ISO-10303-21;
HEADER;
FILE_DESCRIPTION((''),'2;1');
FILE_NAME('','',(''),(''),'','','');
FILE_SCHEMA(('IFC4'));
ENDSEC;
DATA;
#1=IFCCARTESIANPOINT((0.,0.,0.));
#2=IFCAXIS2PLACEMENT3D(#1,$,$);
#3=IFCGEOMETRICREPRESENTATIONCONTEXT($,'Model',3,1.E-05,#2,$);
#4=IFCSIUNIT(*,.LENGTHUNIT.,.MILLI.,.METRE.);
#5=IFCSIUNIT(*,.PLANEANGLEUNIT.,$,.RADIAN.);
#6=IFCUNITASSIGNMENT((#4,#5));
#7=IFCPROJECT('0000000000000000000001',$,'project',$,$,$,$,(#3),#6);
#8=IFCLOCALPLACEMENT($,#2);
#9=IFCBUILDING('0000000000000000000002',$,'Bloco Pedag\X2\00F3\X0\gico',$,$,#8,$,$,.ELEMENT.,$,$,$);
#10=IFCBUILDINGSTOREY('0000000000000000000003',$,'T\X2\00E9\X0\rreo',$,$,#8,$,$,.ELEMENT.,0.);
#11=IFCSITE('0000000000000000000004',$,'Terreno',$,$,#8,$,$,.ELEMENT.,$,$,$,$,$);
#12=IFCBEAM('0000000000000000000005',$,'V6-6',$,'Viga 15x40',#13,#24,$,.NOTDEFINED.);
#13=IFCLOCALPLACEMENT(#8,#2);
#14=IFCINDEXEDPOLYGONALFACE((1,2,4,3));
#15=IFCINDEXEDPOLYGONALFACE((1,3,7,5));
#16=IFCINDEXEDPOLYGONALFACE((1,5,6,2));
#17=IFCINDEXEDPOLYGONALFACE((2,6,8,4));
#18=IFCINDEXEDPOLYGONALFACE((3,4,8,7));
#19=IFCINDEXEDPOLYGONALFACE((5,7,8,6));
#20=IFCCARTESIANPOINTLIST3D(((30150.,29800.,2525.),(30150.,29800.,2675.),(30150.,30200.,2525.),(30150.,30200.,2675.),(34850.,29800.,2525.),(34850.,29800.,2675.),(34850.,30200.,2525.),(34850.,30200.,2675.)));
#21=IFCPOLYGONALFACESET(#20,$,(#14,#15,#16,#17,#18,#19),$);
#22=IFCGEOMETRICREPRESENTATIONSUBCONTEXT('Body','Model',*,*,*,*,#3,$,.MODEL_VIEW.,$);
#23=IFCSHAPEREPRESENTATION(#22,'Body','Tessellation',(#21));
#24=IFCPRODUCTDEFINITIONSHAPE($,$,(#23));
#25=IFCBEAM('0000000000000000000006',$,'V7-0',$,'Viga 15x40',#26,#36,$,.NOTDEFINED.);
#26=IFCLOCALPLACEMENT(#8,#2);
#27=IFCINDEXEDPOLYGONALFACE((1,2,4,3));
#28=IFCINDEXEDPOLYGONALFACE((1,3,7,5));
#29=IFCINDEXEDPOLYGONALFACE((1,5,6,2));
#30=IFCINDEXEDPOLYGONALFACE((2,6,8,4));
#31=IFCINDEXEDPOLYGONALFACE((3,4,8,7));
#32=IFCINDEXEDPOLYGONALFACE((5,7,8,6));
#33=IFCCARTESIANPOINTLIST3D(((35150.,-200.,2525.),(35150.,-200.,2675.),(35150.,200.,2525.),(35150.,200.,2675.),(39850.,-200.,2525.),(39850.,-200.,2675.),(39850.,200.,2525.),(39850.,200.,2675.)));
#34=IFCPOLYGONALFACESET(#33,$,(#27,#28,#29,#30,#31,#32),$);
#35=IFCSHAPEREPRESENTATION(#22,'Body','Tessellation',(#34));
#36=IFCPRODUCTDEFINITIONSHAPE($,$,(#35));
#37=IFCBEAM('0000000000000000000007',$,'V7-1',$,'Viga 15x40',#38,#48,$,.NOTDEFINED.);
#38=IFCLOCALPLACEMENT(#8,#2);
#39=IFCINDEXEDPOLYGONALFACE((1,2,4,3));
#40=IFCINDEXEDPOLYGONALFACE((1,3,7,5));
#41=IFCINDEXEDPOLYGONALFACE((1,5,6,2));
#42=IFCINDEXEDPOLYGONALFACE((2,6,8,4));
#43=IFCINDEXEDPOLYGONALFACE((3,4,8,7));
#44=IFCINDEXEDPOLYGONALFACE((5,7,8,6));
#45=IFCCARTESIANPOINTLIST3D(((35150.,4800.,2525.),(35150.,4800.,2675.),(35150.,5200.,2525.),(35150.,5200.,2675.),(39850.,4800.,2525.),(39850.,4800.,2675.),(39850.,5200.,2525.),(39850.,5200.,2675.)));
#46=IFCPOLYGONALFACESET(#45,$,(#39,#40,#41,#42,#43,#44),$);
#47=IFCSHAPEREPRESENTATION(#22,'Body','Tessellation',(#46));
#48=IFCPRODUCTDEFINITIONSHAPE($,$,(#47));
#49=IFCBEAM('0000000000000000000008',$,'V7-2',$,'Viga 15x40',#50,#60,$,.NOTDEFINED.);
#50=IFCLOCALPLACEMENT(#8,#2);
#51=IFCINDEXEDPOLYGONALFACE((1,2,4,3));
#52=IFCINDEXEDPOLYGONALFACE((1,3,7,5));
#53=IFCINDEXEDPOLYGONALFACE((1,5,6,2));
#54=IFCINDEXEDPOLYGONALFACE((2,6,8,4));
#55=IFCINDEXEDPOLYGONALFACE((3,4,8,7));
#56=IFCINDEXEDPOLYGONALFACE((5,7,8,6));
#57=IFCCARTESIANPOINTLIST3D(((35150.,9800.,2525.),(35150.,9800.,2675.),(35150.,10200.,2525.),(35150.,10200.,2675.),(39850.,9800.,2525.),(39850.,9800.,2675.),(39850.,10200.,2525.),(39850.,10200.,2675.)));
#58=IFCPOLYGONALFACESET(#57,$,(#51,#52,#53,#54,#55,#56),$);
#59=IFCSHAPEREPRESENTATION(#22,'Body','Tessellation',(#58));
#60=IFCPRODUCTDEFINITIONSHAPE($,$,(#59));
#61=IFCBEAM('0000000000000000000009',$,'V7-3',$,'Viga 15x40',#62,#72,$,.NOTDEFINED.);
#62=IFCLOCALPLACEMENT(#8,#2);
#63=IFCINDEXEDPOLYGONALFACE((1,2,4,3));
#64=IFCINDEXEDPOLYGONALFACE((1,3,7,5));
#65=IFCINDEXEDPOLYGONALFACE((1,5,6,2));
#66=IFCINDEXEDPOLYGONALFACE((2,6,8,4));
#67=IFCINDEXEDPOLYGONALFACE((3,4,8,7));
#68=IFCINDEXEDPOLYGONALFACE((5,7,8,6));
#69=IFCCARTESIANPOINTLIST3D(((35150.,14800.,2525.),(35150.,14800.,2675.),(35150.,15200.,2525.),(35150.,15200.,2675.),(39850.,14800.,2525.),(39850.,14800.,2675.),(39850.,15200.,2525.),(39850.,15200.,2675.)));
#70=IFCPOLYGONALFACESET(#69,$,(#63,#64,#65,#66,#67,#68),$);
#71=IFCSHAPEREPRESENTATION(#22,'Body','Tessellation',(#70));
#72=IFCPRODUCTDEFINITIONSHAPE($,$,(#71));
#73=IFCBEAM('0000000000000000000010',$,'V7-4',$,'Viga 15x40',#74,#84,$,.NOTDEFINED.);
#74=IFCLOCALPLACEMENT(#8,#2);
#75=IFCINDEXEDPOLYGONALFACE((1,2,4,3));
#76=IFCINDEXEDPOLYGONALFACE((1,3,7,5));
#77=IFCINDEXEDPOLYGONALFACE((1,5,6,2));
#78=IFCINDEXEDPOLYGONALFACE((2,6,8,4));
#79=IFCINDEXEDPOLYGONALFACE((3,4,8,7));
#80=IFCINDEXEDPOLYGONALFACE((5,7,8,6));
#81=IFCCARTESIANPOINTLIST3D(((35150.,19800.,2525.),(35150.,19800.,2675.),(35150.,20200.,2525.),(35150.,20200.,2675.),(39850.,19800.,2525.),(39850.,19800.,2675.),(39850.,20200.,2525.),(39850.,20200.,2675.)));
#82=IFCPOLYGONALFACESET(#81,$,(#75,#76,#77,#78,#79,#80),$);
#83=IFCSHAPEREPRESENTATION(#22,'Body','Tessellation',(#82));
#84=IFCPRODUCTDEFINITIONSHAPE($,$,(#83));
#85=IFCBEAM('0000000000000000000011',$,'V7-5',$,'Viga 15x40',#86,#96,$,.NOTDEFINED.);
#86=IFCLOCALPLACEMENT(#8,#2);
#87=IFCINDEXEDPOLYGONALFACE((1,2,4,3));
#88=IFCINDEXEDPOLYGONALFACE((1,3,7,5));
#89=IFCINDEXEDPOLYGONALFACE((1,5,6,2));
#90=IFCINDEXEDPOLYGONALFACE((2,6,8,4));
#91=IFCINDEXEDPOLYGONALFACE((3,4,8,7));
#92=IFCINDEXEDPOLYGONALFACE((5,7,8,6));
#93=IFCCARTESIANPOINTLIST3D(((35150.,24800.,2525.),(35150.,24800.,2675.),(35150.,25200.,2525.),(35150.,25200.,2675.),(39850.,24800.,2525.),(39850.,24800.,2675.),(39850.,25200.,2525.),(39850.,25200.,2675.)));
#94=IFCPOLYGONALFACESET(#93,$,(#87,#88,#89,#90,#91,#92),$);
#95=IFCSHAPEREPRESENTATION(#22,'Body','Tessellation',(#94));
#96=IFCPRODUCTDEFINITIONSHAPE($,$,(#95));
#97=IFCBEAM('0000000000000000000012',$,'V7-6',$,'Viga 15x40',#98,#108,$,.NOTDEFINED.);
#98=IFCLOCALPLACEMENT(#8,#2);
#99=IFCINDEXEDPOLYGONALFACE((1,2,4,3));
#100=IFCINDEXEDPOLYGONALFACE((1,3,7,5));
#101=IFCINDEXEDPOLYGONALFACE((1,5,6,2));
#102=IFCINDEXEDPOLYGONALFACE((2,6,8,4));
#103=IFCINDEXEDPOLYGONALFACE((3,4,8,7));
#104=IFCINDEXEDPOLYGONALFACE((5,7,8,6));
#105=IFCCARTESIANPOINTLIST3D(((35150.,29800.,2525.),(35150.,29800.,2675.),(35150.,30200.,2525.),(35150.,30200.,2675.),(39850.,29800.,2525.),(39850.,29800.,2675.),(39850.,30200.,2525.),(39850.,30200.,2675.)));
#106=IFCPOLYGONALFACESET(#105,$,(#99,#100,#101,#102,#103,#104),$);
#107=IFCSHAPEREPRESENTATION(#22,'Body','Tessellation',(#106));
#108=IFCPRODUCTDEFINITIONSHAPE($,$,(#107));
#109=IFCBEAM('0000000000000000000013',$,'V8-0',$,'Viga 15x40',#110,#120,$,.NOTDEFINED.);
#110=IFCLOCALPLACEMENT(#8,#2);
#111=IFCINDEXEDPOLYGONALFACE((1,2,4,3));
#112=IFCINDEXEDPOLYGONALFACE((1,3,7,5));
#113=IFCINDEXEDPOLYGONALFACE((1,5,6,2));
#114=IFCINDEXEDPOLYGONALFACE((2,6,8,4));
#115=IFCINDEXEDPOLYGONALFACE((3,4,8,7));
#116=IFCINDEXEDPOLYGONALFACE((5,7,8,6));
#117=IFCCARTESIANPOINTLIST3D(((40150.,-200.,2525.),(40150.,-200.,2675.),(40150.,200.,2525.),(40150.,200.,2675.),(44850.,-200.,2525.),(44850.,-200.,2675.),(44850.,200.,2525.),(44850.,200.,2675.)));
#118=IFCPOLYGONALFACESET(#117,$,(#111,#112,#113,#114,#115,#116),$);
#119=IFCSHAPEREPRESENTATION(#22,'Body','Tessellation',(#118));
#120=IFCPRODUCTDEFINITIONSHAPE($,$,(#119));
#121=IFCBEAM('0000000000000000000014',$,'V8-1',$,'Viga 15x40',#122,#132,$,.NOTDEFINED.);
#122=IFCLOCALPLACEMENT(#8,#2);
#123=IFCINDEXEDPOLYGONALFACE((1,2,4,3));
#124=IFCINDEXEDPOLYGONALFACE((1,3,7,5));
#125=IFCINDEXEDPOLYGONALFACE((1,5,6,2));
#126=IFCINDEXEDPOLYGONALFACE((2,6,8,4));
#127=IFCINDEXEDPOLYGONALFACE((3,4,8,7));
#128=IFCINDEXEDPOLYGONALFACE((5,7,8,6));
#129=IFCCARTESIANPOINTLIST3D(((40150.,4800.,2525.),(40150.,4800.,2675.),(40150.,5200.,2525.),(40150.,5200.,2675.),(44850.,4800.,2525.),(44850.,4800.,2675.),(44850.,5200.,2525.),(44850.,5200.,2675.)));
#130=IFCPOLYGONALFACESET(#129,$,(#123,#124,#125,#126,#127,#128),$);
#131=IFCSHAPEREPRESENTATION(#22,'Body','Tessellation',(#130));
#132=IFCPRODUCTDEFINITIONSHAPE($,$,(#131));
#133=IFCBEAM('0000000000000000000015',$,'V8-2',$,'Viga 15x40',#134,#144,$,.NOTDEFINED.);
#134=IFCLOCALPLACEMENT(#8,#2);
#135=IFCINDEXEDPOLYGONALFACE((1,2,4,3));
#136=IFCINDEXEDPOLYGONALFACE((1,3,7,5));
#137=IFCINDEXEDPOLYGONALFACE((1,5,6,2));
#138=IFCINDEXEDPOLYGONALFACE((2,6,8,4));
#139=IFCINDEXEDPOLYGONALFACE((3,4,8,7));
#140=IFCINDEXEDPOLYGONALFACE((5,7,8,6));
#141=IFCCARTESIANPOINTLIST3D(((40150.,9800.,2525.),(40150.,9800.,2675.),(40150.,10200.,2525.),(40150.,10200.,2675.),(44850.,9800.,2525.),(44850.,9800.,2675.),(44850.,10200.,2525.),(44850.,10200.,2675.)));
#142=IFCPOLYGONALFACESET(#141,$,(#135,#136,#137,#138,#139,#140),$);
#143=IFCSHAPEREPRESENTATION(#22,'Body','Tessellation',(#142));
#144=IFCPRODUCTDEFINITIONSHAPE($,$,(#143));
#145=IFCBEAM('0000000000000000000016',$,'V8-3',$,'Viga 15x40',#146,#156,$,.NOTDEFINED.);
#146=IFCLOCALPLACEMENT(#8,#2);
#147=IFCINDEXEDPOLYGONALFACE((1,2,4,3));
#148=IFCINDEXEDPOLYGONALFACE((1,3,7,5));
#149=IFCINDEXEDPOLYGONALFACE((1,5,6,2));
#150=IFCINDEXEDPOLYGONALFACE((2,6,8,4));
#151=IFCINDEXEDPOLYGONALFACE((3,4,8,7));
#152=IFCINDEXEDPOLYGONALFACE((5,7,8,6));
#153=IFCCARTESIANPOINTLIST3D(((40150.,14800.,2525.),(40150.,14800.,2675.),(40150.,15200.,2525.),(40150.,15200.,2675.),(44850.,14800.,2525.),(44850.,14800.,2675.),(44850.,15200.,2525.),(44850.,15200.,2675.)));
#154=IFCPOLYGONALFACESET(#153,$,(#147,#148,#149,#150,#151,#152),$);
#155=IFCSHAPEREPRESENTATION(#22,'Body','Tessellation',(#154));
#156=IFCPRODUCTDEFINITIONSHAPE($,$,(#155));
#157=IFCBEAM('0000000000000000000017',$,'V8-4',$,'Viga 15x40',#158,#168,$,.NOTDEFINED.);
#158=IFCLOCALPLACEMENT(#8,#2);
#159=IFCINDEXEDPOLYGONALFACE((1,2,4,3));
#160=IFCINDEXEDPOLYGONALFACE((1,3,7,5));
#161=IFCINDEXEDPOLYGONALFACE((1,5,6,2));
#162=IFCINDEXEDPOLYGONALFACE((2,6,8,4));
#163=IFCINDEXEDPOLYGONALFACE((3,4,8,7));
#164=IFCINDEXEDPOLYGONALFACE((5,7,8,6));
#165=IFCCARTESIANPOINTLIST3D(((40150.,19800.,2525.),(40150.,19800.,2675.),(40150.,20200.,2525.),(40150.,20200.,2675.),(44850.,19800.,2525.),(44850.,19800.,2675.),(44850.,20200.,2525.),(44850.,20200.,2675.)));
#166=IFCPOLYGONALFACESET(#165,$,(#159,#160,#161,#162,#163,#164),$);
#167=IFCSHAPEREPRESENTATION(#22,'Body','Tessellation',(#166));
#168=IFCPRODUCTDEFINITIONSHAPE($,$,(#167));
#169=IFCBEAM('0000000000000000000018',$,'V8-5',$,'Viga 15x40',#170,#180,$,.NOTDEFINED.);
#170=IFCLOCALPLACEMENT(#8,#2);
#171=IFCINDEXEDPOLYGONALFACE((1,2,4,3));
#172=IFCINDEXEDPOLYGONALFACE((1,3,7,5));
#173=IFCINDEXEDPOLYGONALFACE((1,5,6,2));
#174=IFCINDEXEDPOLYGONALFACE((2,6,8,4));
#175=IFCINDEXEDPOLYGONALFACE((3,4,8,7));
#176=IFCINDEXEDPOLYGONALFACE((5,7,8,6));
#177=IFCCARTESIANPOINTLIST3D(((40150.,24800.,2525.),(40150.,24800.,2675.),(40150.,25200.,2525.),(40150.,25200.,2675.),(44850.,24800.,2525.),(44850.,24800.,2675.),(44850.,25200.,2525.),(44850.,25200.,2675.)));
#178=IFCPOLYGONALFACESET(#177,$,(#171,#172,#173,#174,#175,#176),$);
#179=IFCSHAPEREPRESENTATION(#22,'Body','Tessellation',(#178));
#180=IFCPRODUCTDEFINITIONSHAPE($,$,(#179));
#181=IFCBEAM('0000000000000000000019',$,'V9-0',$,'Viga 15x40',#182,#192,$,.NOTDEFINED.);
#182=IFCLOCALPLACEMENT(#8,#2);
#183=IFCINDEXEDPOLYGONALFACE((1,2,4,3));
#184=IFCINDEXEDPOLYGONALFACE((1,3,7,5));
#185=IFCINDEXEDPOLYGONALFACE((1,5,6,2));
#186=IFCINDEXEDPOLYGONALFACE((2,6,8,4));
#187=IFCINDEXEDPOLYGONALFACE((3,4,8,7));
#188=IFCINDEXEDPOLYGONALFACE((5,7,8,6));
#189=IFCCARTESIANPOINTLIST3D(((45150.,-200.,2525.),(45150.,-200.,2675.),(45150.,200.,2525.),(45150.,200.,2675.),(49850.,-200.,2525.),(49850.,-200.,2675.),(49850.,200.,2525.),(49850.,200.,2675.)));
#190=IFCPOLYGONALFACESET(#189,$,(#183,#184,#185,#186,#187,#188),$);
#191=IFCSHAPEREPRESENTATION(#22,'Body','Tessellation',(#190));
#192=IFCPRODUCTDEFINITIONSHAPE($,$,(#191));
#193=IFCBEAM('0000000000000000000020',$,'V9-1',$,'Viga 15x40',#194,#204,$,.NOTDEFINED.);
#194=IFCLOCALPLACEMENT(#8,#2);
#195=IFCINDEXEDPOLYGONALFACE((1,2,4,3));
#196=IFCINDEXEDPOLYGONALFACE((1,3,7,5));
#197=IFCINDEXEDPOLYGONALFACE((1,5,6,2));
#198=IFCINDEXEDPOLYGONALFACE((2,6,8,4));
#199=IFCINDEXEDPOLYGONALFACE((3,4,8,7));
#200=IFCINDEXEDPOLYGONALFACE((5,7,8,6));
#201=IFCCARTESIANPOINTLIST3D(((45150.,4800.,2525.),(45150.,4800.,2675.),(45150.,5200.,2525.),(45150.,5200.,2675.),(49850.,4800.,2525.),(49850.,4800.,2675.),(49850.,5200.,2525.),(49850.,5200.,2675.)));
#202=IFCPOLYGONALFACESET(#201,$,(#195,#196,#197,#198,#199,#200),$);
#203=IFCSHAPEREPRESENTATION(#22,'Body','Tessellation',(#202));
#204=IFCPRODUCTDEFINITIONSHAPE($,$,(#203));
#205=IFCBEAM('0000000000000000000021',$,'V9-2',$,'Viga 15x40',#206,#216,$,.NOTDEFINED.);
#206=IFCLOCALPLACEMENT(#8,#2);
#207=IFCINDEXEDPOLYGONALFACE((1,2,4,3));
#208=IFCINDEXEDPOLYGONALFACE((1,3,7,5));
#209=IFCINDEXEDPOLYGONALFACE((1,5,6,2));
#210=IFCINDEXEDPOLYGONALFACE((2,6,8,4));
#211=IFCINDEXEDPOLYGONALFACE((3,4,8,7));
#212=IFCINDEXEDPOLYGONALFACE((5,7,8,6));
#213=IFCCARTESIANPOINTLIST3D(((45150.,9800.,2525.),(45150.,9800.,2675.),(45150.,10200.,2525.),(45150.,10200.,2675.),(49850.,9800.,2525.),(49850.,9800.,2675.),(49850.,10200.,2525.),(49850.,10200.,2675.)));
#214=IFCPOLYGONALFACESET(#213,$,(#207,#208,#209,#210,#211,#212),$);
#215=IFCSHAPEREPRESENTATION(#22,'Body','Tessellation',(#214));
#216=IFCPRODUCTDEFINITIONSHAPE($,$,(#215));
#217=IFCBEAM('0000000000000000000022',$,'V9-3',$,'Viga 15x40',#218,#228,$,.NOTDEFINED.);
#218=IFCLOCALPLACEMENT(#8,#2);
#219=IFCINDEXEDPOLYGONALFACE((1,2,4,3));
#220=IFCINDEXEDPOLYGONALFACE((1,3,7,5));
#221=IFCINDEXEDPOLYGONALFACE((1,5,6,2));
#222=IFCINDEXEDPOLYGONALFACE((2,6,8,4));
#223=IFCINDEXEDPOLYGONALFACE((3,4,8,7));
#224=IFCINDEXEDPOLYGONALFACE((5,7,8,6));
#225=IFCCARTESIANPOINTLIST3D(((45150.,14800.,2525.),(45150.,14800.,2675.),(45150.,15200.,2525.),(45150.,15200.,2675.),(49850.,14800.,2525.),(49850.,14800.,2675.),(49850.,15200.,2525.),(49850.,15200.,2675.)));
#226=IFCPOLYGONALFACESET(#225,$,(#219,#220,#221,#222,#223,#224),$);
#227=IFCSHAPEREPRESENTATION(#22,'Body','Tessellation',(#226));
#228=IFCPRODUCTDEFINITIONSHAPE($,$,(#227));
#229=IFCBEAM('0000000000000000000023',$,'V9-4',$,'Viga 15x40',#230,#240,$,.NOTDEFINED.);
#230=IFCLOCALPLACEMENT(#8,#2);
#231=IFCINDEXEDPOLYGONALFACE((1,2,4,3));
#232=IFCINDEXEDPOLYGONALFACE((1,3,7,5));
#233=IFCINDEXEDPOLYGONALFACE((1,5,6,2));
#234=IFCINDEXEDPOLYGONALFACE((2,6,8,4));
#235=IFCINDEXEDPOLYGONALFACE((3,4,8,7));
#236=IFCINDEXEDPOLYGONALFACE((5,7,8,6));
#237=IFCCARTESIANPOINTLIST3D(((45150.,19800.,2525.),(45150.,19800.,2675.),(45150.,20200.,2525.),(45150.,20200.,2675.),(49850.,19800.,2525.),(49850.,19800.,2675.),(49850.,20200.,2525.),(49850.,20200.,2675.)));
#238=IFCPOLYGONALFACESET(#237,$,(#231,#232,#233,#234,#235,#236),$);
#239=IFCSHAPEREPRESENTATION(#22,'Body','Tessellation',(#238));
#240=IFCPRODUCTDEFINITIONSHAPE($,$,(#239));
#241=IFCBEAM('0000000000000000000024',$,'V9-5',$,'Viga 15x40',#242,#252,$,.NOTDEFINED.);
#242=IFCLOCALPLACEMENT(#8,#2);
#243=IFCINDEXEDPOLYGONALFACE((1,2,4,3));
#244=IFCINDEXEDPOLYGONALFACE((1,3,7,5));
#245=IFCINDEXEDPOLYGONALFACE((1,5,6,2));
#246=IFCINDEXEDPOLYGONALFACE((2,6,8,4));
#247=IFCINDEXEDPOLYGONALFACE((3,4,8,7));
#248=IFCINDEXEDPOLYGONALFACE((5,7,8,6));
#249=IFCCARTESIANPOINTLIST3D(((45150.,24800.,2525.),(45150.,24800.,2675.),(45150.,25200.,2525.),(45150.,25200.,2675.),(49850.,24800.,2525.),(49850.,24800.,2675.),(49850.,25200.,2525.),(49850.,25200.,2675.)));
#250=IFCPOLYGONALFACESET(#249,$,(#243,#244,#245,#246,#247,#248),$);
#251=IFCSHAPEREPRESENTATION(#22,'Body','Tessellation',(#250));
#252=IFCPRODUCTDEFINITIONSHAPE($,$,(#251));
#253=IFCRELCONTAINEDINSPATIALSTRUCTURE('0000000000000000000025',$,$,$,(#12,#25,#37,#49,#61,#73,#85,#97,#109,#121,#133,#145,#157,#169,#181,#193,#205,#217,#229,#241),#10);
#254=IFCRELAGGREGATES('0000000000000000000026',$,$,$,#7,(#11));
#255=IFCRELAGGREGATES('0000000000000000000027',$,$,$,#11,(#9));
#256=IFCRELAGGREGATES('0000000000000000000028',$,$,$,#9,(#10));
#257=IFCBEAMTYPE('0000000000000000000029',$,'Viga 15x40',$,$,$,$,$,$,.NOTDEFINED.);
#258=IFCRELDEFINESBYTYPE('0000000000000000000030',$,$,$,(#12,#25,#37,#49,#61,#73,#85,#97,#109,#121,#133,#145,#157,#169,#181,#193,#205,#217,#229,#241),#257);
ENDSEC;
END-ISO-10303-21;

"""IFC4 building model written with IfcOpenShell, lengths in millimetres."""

from ifc_helpers import new_model, si_unit, frame, origin, origin_2d, place, context, subcontext, project, spatial, rectangle, extrude, type_object, element, save


model = new_model("IFC4")

# Units and contexts
model_context = context("Model", 3, precision=1e-05, world=origin())
body_context = subcontext(model_context, "Body", "Model", "MODEL_VIEW")
ifc_project = project(units=[si_unit("LENGTHUNIT", "METRE", prefix="MILLI"), si_unit("PLANEANGLEUNIT", "RADIAN")], contexts=[model_context])

# Site, building, storey
placement = place(None, origin())
site = spatial("IfcSite", under=ifc_project, at=placement, Name="Terreno", CompositionType="ELEMENT")
building = spatial("IfcBuilding", under=site, at=placement, Name="Bloco Pedagógico", CompositionType="ELEMENT")
storey = spatial("IfcBuildingStorey", under=building, at=placement, Name="Térreo", CompositionType="ELEMENT", Elevation=0.0)

# Beams
beam_type = type_object("IfcBeamType", Name="Viga 15x40", PredefinedType="NOTDEFINED")
for number, where, z_axis, x_axis, name in (
    (1, (30150.0, 30000.0, 2600.0), (1.0, 0.0, 0.0), (0.0, 1.0, 0.0), "V6-6"),
    (2, (35150.0, 0.0, 2600.0), (1.0, 0.0, 0.0), (0.0, 1.0, 0.0), "V7-0"),
    (3, (35150.0, 5000.0, 2600.0), (1.0, 0.0, 0.0), (0.0, 1.0, 0.0), "V7-1"),
    (4, (35150.0, 10000.0, 2600.0), (1.0, 0.0, 0.0), (0.0, 1.0, 0.0), "V7-2"),
    (5, (35150.0, 15000.0, 2600.0), (1.0, 0.0, 0.0), (0.0, 1.0, 0.0), "V7-3"),
    (6, (35150.0, 20000.0, 2600.0), (1.0, 0.0, 0.0), (0.0, 1.0, 0.0), "V7-4"),
    (7, (35150.0, 25000.0, 2600.0), (1.0, 0.0, 0.0), (0.0, 1.0, 0.0), "V7-5"),
    (8, (35150.0, 30000.0, 2600.0), (1.0, 0.0, 0.0), (0.0, 1.0, 0.0), "V7-6"),
    (9, (40150.0, 0.0, 2600.0), (1.0, 0.0, 0.0), (0.0, 1.0, 0.0), "V8-0"),
    (10, (40150.0, 5000.0, 2600.0), (1.0, 0.0, 0.0), (0.0, 1.0, 0.0), "V8-1"),
    (11, (40150.0, 10000.0, 2600.0), (1.0, 0.0, 0.0), (0.0, 1.0, 0.0), "V8-2"),
    (12, (40150.0, 15000.0, 2600.0), (1.0, 0.0, 0.0), (0.0, 1.0, 0.0), "V8-3"),
    (13, (40150.0, 20000.0, 2600.0), (1.0, 0.0, 0.0), (0.0, 1.0, 0.0), "V8-4"),
    (14, (40150.0, 25000.0, 2600.0), (1.0, 0.0, 0.0), (0.0, 1.0, 0.0), "V8-5"),
    (15, (45150.0, 0.0, 2600.0), (1.0, 0.0, 0.0), (0.0, 1.0, 0.0), "V9-0"),
    (16, (45150.0, 5000.0, 2600.0), (1.0, 0.0, 0.0), (0.0, 1.0, 0.0), "V9-1"),
    (17, (45150.0, 10000.0, 2600.0), (1.0, 0.0, 0.0), (0.0, 1.0, 0.0), "V9-2"),
    (18, (45150.0, 15000.0, 2600.0), (1.0, 0.0, 0.0), (0.0, 1.0, 0.0), "V9-3"),
    (19, (45150.0, 20000.0, 2600.0), (1.0, 0.0, 0.0), (0.0, 1.0, 0.0), "V9-4"),
    (20, (45150.0, 25000.0, 2600.0), (1.0, 0.0, 0.0), (0.0, 1.0, 0.0), "V9-5"),
):
    element("IfcBeam", number, at=place(None, frame(where, z_axis=z_axis, x_axis=x_axis)), inside=storey, type_object=beam_type, Name=name, ObjectType="Viga 15x40", PredefinedType="NOTDEFINED", context=body_context, shape_type="SweptSolid", body=[
        extrude(rectangle(XDim=400.0, YDim=150.0, at=origin_2d()), None, (0.0, 0.0, 1.0), 4700.0),
    ])

save(model, "model.ifc")
